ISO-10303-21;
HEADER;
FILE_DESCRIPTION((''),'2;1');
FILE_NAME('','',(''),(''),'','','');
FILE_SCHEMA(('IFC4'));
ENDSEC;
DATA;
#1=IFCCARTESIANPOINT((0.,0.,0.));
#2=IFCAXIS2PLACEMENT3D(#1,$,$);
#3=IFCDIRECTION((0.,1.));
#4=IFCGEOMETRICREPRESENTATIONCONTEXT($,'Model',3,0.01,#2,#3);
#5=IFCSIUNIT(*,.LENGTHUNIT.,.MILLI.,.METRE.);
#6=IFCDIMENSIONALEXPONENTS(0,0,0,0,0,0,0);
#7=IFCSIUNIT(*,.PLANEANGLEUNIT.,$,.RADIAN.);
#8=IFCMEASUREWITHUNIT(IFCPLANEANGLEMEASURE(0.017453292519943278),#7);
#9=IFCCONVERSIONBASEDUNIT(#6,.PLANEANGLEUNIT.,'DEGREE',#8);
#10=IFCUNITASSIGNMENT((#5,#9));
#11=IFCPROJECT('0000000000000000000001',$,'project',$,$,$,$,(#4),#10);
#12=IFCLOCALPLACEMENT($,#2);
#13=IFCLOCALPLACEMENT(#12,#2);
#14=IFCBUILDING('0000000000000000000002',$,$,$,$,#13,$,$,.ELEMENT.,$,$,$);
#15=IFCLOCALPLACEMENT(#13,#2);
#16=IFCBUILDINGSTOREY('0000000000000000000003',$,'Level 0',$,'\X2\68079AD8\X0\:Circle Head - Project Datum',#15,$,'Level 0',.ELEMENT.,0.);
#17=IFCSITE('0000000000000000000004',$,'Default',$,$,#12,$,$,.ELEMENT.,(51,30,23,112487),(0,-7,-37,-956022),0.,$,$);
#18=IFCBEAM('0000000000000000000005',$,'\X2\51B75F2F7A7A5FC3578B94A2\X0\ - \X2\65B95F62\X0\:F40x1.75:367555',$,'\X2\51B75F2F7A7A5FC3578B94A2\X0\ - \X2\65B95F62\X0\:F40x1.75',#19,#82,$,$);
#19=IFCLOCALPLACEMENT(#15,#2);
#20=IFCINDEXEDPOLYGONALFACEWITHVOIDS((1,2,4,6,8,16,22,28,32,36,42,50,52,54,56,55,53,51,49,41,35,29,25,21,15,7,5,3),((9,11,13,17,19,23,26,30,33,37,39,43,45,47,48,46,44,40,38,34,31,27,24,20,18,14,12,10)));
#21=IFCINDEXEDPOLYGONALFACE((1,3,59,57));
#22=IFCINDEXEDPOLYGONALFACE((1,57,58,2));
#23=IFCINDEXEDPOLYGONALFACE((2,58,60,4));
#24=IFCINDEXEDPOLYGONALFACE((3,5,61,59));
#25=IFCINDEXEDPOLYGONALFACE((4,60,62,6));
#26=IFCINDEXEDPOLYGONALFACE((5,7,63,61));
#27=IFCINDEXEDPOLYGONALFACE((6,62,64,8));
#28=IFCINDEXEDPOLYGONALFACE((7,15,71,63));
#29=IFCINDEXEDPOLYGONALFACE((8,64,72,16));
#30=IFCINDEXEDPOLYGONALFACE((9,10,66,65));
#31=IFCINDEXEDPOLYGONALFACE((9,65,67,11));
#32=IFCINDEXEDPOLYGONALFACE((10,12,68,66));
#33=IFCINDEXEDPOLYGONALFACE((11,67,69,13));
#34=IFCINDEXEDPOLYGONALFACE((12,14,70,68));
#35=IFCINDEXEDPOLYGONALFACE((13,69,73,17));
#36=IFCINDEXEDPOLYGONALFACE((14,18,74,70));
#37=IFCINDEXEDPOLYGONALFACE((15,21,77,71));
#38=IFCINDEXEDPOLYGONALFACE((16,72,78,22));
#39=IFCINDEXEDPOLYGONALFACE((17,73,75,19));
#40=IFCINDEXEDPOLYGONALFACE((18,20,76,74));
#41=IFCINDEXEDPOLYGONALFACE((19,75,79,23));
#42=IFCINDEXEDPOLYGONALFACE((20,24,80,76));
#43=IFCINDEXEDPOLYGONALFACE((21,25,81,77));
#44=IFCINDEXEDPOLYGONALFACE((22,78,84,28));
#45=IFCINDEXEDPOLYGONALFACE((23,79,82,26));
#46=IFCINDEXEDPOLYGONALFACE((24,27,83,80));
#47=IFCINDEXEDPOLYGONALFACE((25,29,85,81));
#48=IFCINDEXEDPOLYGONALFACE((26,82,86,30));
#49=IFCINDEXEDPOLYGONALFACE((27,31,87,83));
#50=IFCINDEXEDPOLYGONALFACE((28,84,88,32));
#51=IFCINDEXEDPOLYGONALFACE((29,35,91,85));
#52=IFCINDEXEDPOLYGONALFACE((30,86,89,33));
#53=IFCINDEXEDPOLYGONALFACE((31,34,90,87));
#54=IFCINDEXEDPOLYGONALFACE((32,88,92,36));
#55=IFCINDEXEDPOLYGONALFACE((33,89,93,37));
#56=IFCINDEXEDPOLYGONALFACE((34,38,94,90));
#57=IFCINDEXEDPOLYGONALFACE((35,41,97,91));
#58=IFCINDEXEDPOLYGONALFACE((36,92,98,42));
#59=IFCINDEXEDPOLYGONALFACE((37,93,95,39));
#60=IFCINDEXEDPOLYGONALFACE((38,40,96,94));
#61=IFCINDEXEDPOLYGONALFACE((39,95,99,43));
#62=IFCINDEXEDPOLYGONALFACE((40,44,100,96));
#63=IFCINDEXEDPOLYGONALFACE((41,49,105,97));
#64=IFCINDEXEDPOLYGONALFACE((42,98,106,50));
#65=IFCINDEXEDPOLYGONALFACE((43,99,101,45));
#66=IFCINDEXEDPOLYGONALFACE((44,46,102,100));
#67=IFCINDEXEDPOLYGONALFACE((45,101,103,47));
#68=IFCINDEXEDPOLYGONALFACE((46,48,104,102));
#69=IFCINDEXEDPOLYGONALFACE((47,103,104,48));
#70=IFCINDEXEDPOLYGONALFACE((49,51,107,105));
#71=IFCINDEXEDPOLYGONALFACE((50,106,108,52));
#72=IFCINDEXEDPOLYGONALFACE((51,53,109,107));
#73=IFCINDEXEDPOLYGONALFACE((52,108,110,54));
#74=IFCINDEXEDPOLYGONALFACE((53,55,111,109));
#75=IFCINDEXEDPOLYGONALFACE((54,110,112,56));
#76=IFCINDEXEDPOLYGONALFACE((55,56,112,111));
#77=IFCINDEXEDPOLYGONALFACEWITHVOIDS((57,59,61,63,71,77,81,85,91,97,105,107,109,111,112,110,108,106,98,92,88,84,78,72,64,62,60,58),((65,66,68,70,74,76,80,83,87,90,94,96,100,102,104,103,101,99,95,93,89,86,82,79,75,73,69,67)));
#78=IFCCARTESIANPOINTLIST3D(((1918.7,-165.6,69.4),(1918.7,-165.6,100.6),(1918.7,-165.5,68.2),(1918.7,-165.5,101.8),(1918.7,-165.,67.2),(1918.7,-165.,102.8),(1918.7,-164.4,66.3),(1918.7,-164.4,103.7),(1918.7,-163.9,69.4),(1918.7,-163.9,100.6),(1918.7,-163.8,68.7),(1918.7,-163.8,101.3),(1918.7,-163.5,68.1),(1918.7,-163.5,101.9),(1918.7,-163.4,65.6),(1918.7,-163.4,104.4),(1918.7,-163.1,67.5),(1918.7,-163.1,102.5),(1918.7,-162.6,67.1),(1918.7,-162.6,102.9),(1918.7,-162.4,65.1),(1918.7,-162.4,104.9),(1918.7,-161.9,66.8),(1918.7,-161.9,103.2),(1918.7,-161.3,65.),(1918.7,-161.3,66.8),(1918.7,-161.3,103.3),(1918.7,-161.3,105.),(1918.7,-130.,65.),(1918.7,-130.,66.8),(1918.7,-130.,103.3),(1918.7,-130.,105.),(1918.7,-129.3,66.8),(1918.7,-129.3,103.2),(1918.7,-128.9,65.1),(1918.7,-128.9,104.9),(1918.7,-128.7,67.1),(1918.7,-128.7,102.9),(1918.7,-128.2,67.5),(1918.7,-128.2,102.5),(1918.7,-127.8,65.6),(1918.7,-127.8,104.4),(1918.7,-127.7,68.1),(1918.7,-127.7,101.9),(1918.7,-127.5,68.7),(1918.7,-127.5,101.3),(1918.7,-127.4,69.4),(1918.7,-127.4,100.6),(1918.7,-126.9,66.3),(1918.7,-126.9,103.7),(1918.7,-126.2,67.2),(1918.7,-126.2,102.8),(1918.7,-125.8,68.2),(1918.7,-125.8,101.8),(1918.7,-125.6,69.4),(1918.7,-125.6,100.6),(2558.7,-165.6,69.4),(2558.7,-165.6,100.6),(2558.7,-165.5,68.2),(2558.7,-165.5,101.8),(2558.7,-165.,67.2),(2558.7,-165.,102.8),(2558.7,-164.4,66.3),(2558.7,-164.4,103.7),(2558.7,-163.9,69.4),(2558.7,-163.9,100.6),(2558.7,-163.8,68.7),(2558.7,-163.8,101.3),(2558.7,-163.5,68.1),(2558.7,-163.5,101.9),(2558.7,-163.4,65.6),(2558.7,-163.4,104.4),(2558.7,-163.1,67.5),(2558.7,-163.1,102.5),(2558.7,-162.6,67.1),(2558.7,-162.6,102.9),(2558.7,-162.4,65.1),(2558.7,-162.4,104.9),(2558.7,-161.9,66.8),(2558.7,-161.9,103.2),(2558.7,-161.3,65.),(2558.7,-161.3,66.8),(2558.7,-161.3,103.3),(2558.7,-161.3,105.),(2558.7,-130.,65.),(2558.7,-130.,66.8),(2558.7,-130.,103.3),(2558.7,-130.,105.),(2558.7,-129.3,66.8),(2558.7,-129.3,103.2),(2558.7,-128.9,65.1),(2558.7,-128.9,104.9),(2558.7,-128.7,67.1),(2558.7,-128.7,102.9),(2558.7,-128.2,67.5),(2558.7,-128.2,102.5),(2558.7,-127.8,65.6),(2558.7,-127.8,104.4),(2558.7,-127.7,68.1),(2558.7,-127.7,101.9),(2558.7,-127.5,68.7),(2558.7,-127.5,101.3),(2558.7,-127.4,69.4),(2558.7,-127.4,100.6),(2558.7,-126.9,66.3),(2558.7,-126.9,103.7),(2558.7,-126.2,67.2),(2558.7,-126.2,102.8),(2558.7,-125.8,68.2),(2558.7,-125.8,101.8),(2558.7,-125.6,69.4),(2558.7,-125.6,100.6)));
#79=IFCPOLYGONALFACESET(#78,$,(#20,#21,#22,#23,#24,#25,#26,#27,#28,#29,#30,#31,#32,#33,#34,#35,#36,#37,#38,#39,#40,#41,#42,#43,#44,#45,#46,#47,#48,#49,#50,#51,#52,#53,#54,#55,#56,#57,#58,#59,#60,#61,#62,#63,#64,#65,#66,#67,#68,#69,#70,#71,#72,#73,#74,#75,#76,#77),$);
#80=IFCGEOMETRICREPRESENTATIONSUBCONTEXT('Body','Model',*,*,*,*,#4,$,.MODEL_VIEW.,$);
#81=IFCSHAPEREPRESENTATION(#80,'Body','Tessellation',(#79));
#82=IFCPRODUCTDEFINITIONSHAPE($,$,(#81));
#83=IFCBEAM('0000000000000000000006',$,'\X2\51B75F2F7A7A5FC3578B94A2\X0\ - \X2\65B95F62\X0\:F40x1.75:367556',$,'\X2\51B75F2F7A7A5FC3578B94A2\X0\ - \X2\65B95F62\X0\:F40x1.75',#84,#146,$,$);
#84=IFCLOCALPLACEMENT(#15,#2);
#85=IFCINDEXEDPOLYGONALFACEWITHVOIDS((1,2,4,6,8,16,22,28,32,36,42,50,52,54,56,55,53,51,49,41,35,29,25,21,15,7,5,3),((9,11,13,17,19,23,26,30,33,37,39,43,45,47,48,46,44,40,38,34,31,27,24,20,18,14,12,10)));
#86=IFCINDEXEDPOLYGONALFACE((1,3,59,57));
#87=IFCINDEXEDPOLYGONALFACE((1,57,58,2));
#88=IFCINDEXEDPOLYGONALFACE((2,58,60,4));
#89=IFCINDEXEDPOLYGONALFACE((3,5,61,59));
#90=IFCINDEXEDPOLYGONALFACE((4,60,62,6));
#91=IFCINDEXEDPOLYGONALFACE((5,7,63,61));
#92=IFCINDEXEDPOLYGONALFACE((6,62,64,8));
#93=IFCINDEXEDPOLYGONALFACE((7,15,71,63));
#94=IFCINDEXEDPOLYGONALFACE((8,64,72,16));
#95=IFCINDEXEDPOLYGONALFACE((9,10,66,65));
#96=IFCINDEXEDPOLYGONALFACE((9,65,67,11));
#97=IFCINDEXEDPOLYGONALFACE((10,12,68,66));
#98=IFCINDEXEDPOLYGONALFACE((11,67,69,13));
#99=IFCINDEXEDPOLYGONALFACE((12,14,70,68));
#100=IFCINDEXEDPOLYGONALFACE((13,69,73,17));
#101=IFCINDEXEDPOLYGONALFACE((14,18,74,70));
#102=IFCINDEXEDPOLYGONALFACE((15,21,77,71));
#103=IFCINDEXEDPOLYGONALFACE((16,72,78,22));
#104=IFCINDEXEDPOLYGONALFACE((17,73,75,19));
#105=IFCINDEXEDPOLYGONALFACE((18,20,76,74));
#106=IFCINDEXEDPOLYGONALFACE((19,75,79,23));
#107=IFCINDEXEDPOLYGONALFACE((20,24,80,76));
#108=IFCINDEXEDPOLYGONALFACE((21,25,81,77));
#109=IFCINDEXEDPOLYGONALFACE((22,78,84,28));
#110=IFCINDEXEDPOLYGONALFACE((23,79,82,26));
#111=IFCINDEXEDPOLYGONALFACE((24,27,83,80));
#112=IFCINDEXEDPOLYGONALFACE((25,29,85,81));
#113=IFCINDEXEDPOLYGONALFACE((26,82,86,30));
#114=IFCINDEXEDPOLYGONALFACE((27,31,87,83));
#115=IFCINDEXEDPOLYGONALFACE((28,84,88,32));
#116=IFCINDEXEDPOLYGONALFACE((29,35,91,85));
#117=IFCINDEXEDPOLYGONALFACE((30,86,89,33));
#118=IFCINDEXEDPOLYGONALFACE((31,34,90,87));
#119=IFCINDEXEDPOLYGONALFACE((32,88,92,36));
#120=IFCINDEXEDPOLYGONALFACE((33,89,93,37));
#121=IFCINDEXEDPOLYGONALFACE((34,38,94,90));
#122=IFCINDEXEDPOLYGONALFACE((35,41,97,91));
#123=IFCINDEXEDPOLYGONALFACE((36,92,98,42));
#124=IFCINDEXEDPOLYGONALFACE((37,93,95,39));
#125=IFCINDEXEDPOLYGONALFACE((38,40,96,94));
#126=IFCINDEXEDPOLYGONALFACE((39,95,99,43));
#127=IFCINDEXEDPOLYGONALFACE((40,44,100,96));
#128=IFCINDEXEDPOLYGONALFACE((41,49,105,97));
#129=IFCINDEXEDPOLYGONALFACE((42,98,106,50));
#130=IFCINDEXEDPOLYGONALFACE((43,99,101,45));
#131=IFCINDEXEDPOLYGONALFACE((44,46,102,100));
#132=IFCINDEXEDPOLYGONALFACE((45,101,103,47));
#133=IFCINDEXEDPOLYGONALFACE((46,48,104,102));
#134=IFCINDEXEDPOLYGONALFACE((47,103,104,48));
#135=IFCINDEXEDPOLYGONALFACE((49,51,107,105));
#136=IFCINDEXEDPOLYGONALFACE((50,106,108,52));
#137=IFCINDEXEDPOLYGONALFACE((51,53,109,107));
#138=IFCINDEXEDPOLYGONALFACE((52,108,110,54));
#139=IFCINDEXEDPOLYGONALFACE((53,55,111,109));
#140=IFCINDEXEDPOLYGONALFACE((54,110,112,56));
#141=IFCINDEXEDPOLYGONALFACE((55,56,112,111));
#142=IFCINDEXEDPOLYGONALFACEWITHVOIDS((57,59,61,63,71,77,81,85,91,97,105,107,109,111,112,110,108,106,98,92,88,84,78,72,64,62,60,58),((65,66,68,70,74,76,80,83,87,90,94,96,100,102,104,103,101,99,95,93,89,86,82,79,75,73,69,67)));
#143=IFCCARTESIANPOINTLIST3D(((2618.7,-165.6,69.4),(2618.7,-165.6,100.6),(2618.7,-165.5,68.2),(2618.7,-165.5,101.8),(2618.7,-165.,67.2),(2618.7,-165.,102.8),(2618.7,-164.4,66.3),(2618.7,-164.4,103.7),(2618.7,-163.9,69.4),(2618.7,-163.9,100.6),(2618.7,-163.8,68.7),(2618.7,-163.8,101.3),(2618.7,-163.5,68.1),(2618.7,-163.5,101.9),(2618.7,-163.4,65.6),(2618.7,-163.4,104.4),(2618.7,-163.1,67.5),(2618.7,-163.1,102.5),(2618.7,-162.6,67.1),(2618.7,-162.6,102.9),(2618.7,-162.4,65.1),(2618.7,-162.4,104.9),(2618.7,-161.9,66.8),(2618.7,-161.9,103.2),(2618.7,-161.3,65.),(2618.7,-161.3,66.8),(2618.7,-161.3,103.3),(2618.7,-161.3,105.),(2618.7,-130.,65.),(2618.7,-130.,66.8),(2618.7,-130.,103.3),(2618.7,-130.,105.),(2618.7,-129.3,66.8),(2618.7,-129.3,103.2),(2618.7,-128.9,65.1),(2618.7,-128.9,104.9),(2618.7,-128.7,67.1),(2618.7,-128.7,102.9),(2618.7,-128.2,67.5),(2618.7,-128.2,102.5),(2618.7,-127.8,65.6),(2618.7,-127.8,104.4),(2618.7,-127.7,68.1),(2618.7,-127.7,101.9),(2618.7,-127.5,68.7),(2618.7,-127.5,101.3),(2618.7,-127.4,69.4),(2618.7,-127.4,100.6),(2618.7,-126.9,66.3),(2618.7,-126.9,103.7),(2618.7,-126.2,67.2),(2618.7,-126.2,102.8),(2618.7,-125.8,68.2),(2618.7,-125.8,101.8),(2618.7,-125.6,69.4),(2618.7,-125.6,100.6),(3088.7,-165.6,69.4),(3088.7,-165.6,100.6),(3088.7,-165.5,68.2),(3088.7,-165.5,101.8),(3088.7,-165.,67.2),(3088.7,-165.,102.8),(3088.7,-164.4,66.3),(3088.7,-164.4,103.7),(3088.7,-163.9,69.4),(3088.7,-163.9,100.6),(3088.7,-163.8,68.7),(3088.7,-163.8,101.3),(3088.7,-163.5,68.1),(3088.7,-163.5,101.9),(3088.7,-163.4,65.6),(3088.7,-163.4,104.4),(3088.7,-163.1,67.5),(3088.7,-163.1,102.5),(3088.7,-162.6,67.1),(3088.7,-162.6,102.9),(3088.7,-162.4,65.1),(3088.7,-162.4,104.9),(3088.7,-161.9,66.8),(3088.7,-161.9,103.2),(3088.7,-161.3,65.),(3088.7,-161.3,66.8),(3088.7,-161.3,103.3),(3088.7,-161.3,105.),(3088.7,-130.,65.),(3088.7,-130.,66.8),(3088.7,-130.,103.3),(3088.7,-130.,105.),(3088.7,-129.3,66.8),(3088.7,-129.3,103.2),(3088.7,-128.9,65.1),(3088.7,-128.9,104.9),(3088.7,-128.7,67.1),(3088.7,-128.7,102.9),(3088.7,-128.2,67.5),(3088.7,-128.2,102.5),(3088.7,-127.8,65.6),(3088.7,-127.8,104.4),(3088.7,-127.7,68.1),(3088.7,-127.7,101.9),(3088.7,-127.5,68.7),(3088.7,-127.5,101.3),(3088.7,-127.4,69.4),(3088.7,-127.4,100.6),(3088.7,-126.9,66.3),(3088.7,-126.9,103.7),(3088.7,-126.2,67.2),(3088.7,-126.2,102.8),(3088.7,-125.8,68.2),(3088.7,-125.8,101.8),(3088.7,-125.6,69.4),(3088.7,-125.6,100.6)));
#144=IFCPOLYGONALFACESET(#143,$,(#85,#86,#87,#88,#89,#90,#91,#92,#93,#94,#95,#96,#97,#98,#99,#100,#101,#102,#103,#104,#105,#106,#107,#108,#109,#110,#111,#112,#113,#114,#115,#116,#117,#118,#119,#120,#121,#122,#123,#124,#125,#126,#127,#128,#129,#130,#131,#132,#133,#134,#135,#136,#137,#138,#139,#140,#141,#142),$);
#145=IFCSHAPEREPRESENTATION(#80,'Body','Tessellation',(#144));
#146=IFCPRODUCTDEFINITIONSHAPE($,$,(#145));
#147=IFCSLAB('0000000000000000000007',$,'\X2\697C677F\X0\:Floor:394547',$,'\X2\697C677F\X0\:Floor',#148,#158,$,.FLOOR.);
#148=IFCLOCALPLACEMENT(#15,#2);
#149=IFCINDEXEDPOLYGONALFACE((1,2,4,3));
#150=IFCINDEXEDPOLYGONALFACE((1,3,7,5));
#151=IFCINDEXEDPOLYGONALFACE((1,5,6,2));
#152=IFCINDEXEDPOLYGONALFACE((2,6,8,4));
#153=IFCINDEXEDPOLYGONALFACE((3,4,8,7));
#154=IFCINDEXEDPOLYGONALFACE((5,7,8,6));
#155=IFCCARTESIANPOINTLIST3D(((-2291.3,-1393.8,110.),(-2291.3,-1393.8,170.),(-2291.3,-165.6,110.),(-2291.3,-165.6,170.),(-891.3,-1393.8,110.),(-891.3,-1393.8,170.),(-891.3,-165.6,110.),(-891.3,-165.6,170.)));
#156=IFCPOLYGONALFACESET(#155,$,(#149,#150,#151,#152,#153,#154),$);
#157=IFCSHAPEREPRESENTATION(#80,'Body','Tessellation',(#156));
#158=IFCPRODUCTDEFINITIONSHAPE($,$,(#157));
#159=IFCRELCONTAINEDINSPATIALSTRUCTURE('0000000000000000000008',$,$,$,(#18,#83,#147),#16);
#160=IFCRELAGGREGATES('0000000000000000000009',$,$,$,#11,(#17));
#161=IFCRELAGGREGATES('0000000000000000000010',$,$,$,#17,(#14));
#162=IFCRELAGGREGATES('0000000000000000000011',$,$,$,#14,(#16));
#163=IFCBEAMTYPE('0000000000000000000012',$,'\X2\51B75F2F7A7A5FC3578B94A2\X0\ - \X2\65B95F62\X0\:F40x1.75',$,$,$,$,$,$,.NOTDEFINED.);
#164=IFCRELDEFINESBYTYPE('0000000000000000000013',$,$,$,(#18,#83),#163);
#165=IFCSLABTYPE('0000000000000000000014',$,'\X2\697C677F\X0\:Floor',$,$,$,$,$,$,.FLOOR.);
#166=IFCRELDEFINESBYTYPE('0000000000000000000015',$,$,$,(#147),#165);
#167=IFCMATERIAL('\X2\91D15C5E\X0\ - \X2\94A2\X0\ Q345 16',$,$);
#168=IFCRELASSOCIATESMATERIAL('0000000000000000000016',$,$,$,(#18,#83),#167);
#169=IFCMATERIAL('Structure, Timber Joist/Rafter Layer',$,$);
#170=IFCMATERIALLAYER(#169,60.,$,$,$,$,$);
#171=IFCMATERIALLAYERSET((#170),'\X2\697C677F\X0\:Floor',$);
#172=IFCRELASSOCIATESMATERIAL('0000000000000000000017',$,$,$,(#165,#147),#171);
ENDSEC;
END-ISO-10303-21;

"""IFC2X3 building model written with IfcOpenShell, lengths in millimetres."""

from ifc_helpers import new_model, entity, si_unit, converted_unit, direction, frame, frame_2d, origin, origin_2d_with_axis, place, context, subcontext, project, spatial, polyline, circle_curve, parameter, trimmed, segment, composite_curve, rectangle, outline, extrude, material, layer, layer_set, layer_usage, type_object, element, save


model = new_model("IFC2X3")

# Units and contexts
model_context = context("Model", 3, precision=0.01, world=origin(), true_north=direction((0.0, 1.0)))
body_context = subcontext(model_context, "Body", "Model", "MODEL_VIEW")
ifc_project = project(units=[si_unit("LENGTHUNIT", "METRE", prefix="MILLI"), converted_unit("PLANEANGLEUNIT", "DEGREE", entity("IfcPlaneAngleMeasure", 0.017453292519943278), si_unit("PLANEANGLEUNIT", "RADIAN"), dimensions=[0, 0, 0, 0, 0, 0, 0])], contexts=[model_context])

# Site, building, storey
site_placement = place(None, origin())
site = spatial("IfcSite", under=ifc_project, at=site_placement, Name="Default", CompositionType="ELEMENT", RefLatitude=(51, 30, 23, 112487), RefLongitude=(0, -7, -37, -956022), RefElevation=0.0)
building_placement = place(site_placement, origin())
building = spatial("IfcBuilding", under=site, at=building_placement, CompositionType="ELEMENT")
storey_placement = place(building_placement, origin())
storey = spatial("IfcBuildingStorey", under=building, at=storey_placement, Name="Level 0", ObjectType="标高:Circle Head - Project Datum", LongName="Level 0", CompositionType="ELEMENT", Elevation=0.0)

# Beams
ifc_material_1 = material(Name="金属 - 钢 Q345 16")
beam_type_1 = type_object("IfcBeamType", Name="冷弯空心型钢 - 方形:F40x1.75", PredefinedType="NOTDEFINED")
beam_1_placement = place(storey_placement, frame((1953.7, -145.6, 105.0)))
element("IfcBeam", 1, at=beam_1_placement, inside=storey, type_object=beam_type_1, material=ifc_material_1, Name="冷弯空心型钢 - 方形:F40x1.75:367555", ObjectType="冷弯空心型钢 - 方形:F40x1.75", context=body_context, shape_type="SweptSolid", body=[
    extrude(outline(composite_curve([segment(trimmed(circle_curve(frame_2d((-15.6, 15.6), x_axis=(1.0, 0.0)), 4.4), [parameter(90.0)], [parameter(180.0)], True, "PARAMETER"), True, "CONTINUOUS"), segment(polyline([(-20.0, 15.6), (-20.0, -15.6)]), True, "CONTINUOUS"), segment(trimmed(circle_curve(frame_2d((-15.6, -15.6), x_axis=(1.0, 0.0)), 4.4), [parameter(180.0)], [parameter(270.0)], True, "PARAMETER"), True, "CONTINUOUS"), segment(polyline([(-15.6, -20.0), (15.6, -20.0)]), True, "CONTINUOUS"), segment(trimmed(circle_curve(frame_2d((15.6, -15.6), x_axis=(1.0, 0.0)), 4.4), [parameter(270.0)], [parameter(0.0)], True, "PARAMETER"), True, "CONTINUOUS"), segment(polyline([(20.0, -15.6), (20.0, 15.6)]), True, "CONTINUOUS"), segment(trimmed(circle_curve(frame_2d((15.6, 15.6), x_axis=(1.0, 0.0)), 4.4), [parameter(0.0)], [parameter(90.0)], True, "PARAMETER"), True, "CONTINUOUS"), segment(polyline([(15.6, 20.0), (-15.6, 20.0)]), True, "CONTINUOUS")], self_intersect=False), holes=[composite_curve([segment(polyline([(-15.6, 18.3), (15.6, 18.3)]), True, "CONTINUOUS"), segment(trimmed(circle_curve(frame_2d((15.6, 15.6), x_axis=(1.0, 0.0)), 2.6), [parameter(0.0)], [parameter(90.0)], True, "PARAMETER"), False, "CONTINUOUS"), segment(polyline([(18.2, 15.6), (18.2, -15.6)]), True, "CONTINUOUS"), segment(trimmed(circle_curve(frame_2d((15.6, -15.6), x_axis=(1.0, 0.0)), 2.6), [parameter(270.0)], [parameter(360.0)], True, "PARAMETER"), False, "CONTINUOUS"), segment(polyline([(15.6, -18.2), (-15.6, -18.2)]), True, "CONTINUOUS"), segment(trimmed(circle_curve(frame_2d((-15.6, -15.6), x_axis=(1.0, 0.0)), 2.6), [parameter(180.0)], [parameter(270.0)], True, "PARAMETER"), False, "CONTINUOUS"), segment(polyline([(-18.3, -15.6), (-18.3, 15.6)]), True, "CONTINUOUS"), segment(trimmed(circle_curve(frame_2d((-15.6, 15.6), x_axis=(1.0, 0.0)), 2.6), [parameter(90.0)], [parameter(180.0)], True, "PARAMETER"), False, "CONTINUOUS")], self_intersect=False)]), frame((-35.0, 0.0, -20.0), z_axis=(1.0, 0.0, 0.0), x_axis=(0.0, 1.0, 0.0)), (0.0, 0.0, 1.0), 640.0),
])
beam_2_placement = place(storey_placement, frame((2653.7, -145.6, 105.0)))
element("IfcBeam", 2, at=beam_2_placement, inside=storey, type_object=beam_type_1, material=ifc_material_1, Name="冷弯空心型钢 - 方形:F40x1.75:367556", ObjectType="冷弯空心型钢 - 方形:F40x1.75", context=body_context, shape_type="SweptSolid", body=[
    extrude(outline(composite_curve([segment(trimmed(circle_curve(frame_2d((-15.6, 15.6), x_axis=(1.0, 0.0)), 4.4), [parameter(90.0)], [parameter(180.0)], True, "PARAMETER"), True, "CONTINUOUS"), segment(polyline([(-20.0, 15.6), (-20.0, -15.6)]), True, "CONTINUOUS"), segment(trimmed(circle_curve(frame_2d((-15.6, -15.6), x_axis=(1.0, 0.0)), 4.4), [parameter(180.0)], [parameter(270.0)], True, "PARAMETER"), True, "CONTINUOUS"), segment(polyline([(-15.6, -20.0), (15.6, -20.0)]), True, "CONTINUOUS"), segment(trimmed(circle_curve(frame_2d((15.6, -15.6), x_axis=(1.0, 0.0)), 4.4), [parameter(270.0)], [parameter(0.0)], True, "PARAMETER"), True, "CONTINUOUS"), segment(polyline([(20.0, -15.6), (20.0, 15.6)]), True, "CONTINUOUS"), segment(trimmed(circle_curve(frame_2d((15.6, 15.6), x_axis=(1.0, 0.0)), 4.4), [parameter(0.0)], [parameter(90.0)], True, "PARAMETER"), True, "CONTINUOUS"), segment(polyline([(15.6, 20.0), (-15.6, 20.0)]), True, "CONTINUOUS")], self_intersect=False), holes=[composite_curve([segment(polyline([(-15.6, 18.3), (15.6, 18.3)]), True, "CONTINUOUS"), segment(trimmed(circle_curve(frame_2d((15.6, 15.6), x_axis=(1.0, 0.0)), 2.6), [parameter(0.0)], [parameter(90.0)], True, "PARAMETER"), False, "CONTINUOUS"), segment(polyline([(18.2, 15.6), (18.2, -15.6)]), True, "CONTINUOUS"), segment(trimmed(circle_curve(frame_2d((15.6, -15.6), x_axis=(1.0, 0.0)), 2.6), [parameter(270.0)], [parameter(360.0)], True, "PARAMETER"), False, "CONTINUOUS"), segment(polyline([(15.6, -18.2), (-15.6, -18.2)]), True, "CONTINUOUS"), segment(trimmed(circle_curve(frame_2d((-15.6, -15.6), x_axis=(1.0, 0.0)), 2.6), [parameter(180.0)], [parameter(270.0)], True, "PARAMETER"), False, "CONTINUOUS"), segment(polyline([(-18.3, -15.6), (-18.3, 15.6)]), True, "CONTINUOUS"), segment(trimmed(circle_curve(frame_2d((-15.6, 15.6), x_axis=(1.0, 0.0)), 2.6), [parameter(90.0)], [parameter(180.0)], True, "PARAMETER"), False, "CONTINUOUS")], self_intersect=False)]), frame((-35.0, 0.0, -20.0), z_axis=(1.0, 0.0, 0.0), x_axis=(0.0, 1.0, 0.0)), (0.0, 0.0, 1.0), 470.0),
])

# Slab
ifc_material_2 = material(Name="Structure, Timber Joist/Rafter Layer")
ifc_layer_1 = layer(ifc_material_2, 60.0)
ifc_layer_set_1 = layer_set([ifc_layer_1], Name="楼板:Floor")
ifc_layer_usage_1 = layer_usage(ifc_layer_set_1, "AXIS3", "POSITIVE", 0.0)
slab_type = type_object("IfcSlabType", Name="楼板:Floor", PredefinedType="FLOOR", material=ifc_layer_set_1)
slab_1_placement = place(storey_placement, origin())
element("IfcSlab", 3, at=slab_1_placement, inside=storey, type_object=slab_type, material=ifc_layer_usage_1, Name="楼板:Floor:394547", ObjectType="楼板:Floor", PredefinedType="FLOOR", context=body_context, shape_type="SweptSolid", body=[
    extrude(rectangle(XDim=1228.1, YDim=1400.0, at=origin_2d_with_axis()), frame((-1591.3, -779.7, 170.0), z_axis=(0.0, 0.0, -1.0), x_axis=(0.0, 1.0, 0.0)), (0.0, 0.0, 1.0), 60.0),
])

save(model, "model.ifc")
